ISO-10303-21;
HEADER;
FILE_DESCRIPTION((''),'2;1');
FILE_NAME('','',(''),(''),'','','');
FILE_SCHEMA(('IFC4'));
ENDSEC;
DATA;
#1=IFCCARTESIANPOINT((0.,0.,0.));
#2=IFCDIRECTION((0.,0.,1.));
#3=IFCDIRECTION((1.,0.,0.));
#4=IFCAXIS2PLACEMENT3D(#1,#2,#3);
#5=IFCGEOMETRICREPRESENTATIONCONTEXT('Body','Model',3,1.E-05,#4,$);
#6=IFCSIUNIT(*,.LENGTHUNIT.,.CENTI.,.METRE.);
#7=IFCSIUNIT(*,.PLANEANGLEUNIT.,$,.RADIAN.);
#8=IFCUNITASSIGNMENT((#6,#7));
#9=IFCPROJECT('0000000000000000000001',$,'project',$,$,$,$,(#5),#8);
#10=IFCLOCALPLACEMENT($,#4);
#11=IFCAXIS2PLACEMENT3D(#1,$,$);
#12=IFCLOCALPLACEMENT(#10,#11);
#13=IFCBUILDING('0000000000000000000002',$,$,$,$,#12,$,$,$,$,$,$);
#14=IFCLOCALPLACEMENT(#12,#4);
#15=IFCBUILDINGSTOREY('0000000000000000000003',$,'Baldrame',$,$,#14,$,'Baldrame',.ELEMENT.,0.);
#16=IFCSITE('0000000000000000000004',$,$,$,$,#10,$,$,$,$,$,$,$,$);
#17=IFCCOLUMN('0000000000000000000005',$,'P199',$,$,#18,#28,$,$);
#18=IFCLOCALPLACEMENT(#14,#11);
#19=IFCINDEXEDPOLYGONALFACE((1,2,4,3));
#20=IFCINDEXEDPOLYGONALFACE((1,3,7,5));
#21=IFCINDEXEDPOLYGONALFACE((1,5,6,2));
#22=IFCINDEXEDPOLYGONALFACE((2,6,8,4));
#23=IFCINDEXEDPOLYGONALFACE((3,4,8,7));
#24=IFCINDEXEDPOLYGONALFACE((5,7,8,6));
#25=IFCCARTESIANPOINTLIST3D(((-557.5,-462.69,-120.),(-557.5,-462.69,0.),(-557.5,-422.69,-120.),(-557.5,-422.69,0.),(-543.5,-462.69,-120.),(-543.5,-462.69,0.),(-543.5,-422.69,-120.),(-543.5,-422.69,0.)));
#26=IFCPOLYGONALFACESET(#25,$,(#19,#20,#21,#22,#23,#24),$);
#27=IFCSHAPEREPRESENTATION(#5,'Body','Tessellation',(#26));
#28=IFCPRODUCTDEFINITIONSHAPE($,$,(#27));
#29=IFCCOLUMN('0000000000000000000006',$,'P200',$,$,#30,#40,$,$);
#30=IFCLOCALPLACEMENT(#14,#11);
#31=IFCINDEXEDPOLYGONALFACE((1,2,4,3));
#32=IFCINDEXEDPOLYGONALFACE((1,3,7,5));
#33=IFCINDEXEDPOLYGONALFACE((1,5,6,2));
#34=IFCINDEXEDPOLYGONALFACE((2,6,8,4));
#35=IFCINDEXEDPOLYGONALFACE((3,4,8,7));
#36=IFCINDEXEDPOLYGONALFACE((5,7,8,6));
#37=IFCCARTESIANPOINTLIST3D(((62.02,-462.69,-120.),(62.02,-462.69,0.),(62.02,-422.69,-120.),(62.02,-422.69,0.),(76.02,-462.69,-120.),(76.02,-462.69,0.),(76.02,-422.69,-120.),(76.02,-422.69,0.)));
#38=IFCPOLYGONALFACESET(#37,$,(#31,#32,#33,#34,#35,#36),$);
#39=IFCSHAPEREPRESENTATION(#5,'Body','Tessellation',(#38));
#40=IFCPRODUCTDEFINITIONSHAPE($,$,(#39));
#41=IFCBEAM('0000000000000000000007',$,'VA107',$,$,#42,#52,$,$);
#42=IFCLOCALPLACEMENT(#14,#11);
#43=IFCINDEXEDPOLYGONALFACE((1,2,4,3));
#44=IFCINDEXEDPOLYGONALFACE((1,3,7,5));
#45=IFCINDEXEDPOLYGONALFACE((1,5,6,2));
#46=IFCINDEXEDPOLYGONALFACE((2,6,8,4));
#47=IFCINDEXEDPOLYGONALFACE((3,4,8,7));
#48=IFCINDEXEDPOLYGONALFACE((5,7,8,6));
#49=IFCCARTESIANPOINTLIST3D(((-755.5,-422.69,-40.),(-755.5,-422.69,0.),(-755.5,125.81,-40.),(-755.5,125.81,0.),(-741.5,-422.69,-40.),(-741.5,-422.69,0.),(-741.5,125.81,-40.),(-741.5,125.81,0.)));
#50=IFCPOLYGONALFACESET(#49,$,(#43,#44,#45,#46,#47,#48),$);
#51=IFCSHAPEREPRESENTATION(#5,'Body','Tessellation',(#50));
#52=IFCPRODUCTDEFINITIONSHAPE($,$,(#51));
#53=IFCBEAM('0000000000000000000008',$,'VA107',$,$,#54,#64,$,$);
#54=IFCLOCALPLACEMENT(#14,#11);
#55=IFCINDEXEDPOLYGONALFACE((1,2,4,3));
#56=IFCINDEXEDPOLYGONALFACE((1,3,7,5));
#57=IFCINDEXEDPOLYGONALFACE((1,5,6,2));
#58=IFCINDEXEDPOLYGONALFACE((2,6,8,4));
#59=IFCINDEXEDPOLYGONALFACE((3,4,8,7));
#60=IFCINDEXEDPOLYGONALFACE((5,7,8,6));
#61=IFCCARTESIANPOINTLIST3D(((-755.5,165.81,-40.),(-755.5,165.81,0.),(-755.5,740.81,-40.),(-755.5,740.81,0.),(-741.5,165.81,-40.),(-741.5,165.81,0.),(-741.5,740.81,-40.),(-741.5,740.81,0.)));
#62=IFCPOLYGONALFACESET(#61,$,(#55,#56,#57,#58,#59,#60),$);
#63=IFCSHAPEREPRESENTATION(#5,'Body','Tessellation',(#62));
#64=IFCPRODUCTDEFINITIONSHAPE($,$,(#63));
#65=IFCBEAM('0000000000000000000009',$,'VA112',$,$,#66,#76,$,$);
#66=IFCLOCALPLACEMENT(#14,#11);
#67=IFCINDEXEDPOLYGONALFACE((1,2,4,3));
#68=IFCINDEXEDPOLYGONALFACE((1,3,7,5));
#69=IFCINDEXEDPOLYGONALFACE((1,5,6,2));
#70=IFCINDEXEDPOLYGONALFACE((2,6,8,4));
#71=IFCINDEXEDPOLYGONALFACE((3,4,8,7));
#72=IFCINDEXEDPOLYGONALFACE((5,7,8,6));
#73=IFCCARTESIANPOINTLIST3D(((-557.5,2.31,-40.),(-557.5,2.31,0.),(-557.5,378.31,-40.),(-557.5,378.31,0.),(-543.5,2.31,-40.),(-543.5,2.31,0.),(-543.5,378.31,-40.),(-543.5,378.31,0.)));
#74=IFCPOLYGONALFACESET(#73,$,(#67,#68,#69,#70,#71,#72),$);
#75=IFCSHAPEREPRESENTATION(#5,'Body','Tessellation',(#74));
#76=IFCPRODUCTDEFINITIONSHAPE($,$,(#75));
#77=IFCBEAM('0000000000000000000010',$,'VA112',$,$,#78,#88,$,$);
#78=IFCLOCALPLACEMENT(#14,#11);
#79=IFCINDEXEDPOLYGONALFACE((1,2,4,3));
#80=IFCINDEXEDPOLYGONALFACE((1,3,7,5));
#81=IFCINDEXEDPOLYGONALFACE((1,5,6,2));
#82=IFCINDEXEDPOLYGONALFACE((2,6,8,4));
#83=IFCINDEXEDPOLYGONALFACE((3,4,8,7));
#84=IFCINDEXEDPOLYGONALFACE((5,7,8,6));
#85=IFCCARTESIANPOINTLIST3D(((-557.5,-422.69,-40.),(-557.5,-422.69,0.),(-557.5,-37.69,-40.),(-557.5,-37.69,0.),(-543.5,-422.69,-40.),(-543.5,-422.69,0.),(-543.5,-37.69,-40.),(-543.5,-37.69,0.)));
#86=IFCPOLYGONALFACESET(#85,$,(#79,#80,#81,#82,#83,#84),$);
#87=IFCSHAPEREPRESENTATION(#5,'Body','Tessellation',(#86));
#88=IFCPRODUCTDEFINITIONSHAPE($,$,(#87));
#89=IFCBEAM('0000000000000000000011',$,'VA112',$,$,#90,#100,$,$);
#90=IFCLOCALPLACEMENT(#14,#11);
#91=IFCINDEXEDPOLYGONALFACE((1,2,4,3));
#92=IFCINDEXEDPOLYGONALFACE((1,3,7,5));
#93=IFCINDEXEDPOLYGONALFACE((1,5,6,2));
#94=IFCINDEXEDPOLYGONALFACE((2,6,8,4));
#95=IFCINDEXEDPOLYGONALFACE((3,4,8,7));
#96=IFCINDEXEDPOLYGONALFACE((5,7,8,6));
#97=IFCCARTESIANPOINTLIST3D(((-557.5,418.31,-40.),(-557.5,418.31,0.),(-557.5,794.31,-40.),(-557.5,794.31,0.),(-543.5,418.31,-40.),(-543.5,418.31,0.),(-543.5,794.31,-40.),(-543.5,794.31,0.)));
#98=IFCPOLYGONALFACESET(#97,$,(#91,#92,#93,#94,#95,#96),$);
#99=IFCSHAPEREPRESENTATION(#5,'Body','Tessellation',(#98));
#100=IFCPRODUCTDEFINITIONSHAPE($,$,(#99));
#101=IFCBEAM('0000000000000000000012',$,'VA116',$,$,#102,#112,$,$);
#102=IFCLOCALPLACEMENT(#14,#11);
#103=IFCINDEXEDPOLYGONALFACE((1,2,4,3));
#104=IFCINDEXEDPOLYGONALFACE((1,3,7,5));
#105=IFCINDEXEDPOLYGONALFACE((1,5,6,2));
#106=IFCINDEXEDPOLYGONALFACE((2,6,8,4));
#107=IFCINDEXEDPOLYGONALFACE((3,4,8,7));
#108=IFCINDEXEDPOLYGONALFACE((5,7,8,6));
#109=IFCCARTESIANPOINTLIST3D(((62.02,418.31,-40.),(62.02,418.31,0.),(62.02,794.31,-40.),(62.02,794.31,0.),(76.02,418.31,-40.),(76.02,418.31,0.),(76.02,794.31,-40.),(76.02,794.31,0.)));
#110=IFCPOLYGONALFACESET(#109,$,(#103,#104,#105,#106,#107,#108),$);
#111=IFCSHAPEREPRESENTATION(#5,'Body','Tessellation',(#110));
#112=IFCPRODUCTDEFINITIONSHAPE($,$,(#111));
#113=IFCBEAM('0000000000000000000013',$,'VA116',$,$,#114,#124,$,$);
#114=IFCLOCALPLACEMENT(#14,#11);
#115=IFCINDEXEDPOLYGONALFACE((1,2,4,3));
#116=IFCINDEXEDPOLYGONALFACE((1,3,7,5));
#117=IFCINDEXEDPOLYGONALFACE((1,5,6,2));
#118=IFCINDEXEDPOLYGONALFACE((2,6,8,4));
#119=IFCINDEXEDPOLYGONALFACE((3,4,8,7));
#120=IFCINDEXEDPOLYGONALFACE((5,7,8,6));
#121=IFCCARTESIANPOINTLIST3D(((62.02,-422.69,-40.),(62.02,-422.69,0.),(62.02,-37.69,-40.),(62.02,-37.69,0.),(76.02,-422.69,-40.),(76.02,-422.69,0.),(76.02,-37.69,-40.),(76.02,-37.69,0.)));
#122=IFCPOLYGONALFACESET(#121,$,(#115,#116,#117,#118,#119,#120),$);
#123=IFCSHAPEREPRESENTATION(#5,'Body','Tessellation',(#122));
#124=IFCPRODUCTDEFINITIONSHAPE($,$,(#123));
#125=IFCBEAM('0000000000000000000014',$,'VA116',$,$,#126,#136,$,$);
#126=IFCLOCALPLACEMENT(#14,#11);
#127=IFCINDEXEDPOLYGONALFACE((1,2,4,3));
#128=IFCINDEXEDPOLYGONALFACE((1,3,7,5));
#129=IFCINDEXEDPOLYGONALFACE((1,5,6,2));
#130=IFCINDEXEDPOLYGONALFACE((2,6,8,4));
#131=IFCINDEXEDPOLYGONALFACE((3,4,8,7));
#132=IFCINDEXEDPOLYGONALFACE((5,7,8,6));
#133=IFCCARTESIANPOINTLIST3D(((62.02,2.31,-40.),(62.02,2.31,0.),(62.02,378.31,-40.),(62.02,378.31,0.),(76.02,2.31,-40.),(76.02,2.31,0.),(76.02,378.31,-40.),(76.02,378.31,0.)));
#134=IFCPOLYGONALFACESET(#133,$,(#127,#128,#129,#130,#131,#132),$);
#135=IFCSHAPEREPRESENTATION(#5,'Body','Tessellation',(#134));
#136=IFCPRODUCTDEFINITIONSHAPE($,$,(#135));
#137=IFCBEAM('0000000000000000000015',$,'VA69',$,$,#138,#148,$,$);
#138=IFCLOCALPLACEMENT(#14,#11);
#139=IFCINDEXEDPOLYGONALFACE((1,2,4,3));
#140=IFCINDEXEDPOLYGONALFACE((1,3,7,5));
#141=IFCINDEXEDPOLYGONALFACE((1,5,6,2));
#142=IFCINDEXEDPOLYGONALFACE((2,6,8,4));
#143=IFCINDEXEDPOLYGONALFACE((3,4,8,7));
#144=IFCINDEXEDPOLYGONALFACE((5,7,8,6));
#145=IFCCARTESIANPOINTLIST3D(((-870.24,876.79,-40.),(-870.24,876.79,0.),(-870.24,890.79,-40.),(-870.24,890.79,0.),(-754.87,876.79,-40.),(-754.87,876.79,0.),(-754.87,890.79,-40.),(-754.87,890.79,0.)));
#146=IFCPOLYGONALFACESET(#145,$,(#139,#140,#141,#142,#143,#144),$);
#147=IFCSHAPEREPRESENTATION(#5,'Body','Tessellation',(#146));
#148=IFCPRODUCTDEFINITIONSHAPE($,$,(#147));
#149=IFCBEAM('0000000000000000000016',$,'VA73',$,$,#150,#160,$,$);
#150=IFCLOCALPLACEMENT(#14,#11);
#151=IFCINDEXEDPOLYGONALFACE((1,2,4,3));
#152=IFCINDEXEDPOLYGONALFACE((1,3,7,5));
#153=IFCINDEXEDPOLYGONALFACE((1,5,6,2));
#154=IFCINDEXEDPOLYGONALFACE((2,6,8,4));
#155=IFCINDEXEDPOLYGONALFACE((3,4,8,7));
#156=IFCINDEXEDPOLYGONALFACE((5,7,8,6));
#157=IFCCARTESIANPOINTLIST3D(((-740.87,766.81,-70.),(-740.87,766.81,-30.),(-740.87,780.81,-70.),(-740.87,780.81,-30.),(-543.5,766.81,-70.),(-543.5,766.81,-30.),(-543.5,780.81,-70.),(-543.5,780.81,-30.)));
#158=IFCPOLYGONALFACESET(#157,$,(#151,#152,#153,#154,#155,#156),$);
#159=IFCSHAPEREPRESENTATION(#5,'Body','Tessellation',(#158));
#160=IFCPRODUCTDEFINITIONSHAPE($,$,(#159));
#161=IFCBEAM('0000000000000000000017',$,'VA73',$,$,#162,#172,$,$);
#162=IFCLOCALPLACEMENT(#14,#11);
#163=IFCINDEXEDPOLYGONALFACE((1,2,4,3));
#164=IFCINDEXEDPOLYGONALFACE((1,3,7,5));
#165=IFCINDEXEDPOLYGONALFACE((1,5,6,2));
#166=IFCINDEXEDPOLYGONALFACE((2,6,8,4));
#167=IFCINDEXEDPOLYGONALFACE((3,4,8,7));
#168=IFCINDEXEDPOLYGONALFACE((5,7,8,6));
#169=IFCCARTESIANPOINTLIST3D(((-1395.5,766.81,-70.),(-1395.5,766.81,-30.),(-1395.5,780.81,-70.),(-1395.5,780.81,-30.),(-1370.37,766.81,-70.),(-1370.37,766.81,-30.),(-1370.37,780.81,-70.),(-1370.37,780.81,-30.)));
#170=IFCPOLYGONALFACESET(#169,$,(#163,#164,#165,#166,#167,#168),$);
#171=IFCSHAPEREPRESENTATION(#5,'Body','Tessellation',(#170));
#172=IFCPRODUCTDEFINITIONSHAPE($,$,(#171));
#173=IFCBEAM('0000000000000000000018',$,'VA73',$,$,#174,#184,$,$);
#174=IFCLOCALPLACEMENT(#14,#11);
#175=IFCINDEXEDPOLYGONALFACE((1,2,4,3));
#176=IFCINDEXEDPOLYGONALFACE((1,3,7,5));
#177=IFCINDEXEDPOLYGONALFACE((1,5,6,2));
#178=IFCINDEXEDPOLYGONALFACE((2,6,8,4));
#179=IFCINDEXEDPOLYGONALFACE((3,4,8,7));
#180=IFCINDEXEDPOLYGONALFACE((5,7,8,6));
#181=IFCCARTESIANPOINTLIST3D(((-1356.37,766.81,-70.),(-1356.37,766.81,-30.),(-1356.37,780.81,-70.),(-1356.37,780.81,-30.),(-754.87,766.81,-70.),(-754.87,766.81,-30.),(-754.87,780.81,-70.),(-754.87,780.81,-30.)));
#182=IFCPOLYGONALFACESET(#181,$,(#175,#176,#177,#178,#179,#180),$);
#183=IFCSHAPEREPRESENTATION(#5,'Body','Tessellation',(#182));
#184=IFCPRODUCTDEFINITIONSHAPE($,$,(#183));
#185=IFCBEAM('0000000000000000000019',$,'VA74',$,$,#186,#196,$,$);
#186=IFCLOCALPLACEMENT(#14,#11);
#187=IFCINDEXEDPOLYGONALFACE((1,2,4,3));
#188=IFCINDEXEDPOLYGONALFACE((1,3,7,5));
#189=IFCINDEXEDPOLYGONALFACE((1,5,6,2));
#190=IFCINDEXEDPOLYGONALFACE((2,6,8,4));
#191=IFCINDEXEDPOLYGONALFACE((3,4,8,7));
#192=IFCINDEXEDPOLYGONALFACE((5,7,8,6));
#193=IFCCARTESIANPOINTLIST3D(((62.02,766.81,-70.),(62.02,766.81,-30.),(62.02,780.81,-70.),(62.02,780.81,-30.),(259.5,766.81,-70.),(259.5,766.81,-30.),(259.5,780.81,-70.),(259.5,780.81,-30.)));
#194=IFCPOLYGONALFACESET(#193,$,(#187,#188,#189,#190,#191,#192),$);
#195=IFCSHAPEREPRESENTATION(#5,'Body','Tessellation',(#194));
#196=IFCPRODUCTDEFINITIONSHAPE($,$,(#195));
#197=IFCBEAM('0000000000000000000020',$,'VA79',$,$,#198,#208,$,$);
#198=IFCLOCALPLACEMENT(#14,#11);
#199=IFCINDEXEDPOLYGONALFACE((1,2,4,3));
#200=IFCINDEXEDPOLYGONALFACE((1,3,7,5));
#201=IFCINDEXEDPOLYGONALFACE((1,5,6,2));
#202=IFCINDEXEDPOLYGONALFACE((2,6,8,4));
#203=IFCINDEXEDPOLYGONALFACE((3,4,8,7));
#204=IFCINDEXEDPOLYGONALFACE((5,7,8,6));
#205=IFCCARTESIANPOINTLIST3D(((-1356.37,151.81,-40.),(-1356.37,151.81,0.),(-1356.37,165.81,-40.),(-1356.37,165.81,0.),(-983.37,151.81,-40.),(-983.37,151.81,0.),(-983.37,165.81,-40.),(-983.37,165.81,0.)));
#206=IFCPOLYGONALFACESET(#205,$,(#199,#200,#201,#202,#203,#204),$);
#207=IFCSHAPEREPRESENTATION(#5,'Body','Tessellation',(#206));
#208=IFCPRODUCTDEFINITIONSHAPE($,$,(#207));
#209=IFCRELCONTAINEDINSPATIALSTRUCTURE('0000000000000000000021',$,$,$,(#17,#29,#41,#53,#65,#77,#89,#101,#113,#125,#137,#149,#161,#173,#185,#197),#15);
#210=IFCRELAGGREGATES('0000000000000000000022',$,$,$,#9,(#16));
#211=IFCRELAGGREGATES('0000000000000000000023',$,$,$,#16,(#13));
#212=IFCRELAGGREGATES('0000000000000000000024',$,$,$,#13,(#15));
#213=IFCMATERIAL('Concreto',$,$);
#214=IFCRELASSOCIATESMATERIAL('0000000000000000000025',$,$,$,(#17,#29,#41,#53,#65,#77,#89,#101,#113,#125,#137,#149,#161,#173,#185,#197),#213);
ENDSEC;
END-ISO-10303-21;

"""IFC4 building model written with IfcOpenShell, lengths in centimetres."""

from ifc_helpers import new_model, si_unit, frame, origin, origin_with_axes, origin_2d_with_axis, place, context, project, spatial, rectangle, extrude, material, element, save


model = new_model("IFC4")

# Units and contexts
model_context = context("Model", 3, precision=1e-05, world=origin_with_axes(), identifier="Body")
ifc_project = project(units=[si_unit("LENGTHUNIT", "METRE", prefix="CENTI"), si_unit("PLANEANGLEUNIT", "RADIAN")], contexts=[model_context])

# Site, building, storey
site_placement = place(None, origin_with_axes())
site = spatial("IfcSite", under=ifc_project, at=site_placement)
building_placement = place(site_placement, origin())
building = spatial("IfcBuilding", under=site, at=building_placement)
storey_placement = place(building_placement, origin_with_axes())
storey = spatial("IfcBuildingStorey", under=building, at=storey_placement, Name="Baldrame", LongName="Baldrame", CompositionType="ELEMENT", Elevation=0.0)

# Shared definitions
ifc_material = material(Name="Concreto")

# Columns
for number, where, z_axis, x_axis, name in (
    (1, (-550.5, -442.69, 0.0), (0.0, 0.0, 1.0), (1.0, 0.0, 0.0), "P199"),
    (2, (69.02, -442.69, 0.0), (0.0, 0.0, 1.0), (1.0, 0.0, 0.0), "P200"),
):
    element("IfcColumn", number, at=place(storey_placement, frame(where, z_axis=z_axis, x_axis=x_axis)), inside=storey, material=ifc_material, Name=name, context=model_context, shape_type="SolidModel", body=[
        extrude(rectangle(XDim=14.0, YDim=40.0, at=origin_2d_with_axis()), frame((0.0, 0.0, -120.0), z_axis=(0.0, 0.0, 1.0), x_axis=(1.0, 0.0, 0.0)), (0.0, 0.0, 1.0), 120.0),
    ])

# Beams
beam_1_placement = place(storey_placement, frame((-748.5, -148.44, 0.0), z_axis=(0.0, 0.0, 1.0), x_axis=(1.0, 0.0, 0.0)))
element("IfcBeam", 3, at=beam_1_placement, inside=storey, material=ifc_material, Name="VA107", context=model_context, shape_type="SolidModel", body=[
    extrude(rectangle(XDim=14.0, YDim=40.0, at=origin_2d_with_axis()), frame((0.0, -274.25, -20.0), z_axis=(0.0, 1.0, 0.0), x_axis=(-1.0, 0.0, 0.0)), (0.0, 0.0, 1.0), 548.5),
])
beam_2_placement = place(storey_placement, frame((-748.5, 453.31, 0.0), z_axis=(0.0, 0.0, 1.0), x_axis=(1.0, 0.0, 0.0)))
element("IfcBeam", 4, at=beam_2_placement, inside=storey, material=ifc_material, Name="VA107", context=model_context, shape_type="SolidModel", body=[
    extrude(rectangle(XDim=14.0, YDim=40.0, at=origin_2d_with_axis()), frame((0.0, -287.5, -20.0), z_axis=(0.0, 1.0, 0.0), x_axis=(-1.0, 0.0, 0.0)), (0.0, 0.0, 1.0), 575.0),
])
beam_3_placement = place(storey_placement, frame((-550.5, 190.31, 0.0), z_axis=(0.0, 0.0, 1.0), x_axis=(1.0, 0.0, 0.0)))
element("IfcBeam", 5, at=beam_3_placement, inside=storey, material=ifc_material, Name="VA112", context=model_context, shape_type="SolidModel", body=[
    extrude(rectangle(XDim=14.0, YDim=40.0, at=origin_2d_with_axis()), frame((0.0, -188.0, -20.0), z_axis=(0.0, 1.0, 0.0), x_axis=(-1.0, 0.0, 0.0)), (0.0, 0.0, 1.0), 376.0),
])
beam_4_placement = place(storey_placement, frame((-550.5, -230.19, 0.0), z_axis=(0.0, 0.0, 1.0), x_axis=(1.0, 0.0, 0.0)))
element("IfcBeam", 6, at=beam_4_placement, inside=storey, material=ifc_material, Name="VA112", context=model_context, shape_type="SolidModel", body=[
    extrude(rectangle(XDim=14.0, YDim=40.0, at=origin_2d_with_axis()), frame((0.0, -192.5, -20.0), z_axis=(0.0, 1.0, 0.0), x_axis=(-1.0, 0.0, 0.0)), (0.0, 0.0, 1.0), 385.0),
])
for number, where, z_axis, x_axis, name in (
    (7, (-550.5, 606.31, 0.0), (0.0, 0.0, 1.0), (1.0, 0.0, 0.0), "VA112"),
    (8, (69.02, 606.31, 0.0), (0.0, 0.0, 1.0), (1.0, 0.0, 0.0), "VA116"),
):
    element("IfcBeam", number, at=place(storey_placement, frame(where, z_axis=z_axis, x_axis=x_axis)), inside=storey, material=ifc_material, Name=name, context=model_context, shape_type="SolidModel", body=[
        extrude(rectangle(XDim=14.0, YDim=40.0, at=origin_2d_with_axis()), frame((0.0, -188.0, -20.0), z_axis=(0.0, 1.0, 0.0), x_axis=(-1.0, 0.0, 0.0)), (0.0, 0.0, 1.0), 376.0),
    ])
beam_5_placement = place(storey_placement, frame((69.02, -230.19, 0.0), z_axis=(0.0, 0.0, 1.0), x_axis=(1.0, 0.0, 0.0)))
element("IfcBeam", 9, at=beam_5_placement, inside=storey, material=ifc_material, Name="VA116", context=model_context, shape_type="SolidModel", body=[
    extrude(rectangle(XDim=14.0, YDim=40.0, at=origin_2d_with_axis()), frame((0.0, -192.5, -20.0), z_axis=(0.0, 1.0, 0.0), x_axis=(1.0, 0.0, 0.0)), (0.0, 0.0, 1.0), 385.0),
])
beam_6_placement = place(storey_placement, frame((69.02, 190.31, 0.0), z_axis=(0.0, 0.0, 1.0), x_axis=(1.0, 0.0, 0.0)))
element("IfcBeam", 10, at=beam_6_placement, inside=storey, material=ifc_material, Name="VA116", context=model_context, shape_type="SolidModel", body=[
    extrude(rectangle(XDim=14.0, YDim=40.0, at=origin_2d_with_axis()), frame((0.0, -188.0, -20.0), z_axis=(0.0, 1.0, 0.0), x_axis=(1.0, 0.0, 0.0)), (0.0, 0.0, 1.0), 376.0),
])
beam_7_placement = place(storey_placement, frame((-812.56, 883.79, 0.0), z_axis=(0.0, 0.0, 1.0), x_axis=(1.0, 0.0, 0.0)))
element("IfcBeam", 11, at=beam_7_placement, inside=storey, material=ifc_material, Name="VA69", context=model_context, shape_type="SolidModel", body=[
    extrude(rectangle(XDim=14.0, YDim=40.0, at=origin_2d_with_axis()), frame((-57.69, 0.0, -20.0), z_axis=(1.0, 0.0, 0.0), x_axis=(0.0, 1.0, 0.0)), (0.0, 0.0, 1.0), 115.37),
])
beam_8_placement = place(storey_placement, frame((-642.18, 773.81, -30.0), z_axis=(0.0, 0.0, 1.0), x_axis=(1.0, 0.0, 0.0)))
element("IfcBeam", 12, at=beam_8_placement, inside=storey, material=ifc_material, Name="VA73", context=model_context, shape_type="SolidModel", body=[
    extrude(rectangle(XDim=14.0, YDim=40.0, at=origin_2d_with_axis()), frame((-98.69, 0.0, -20.0), z_axis=(1.0, 0.0, 0.0), x_axis=(0.0, 1.0, 0.0)), (0.0, 0.0, 1.0), 197.37),
])
beam_9_placement = place(storey_placement, frame((-1382.93, 773.81, -30.0), z_axis=(0.0, 0.0, 1.0), x_axis=(1.0, 0.0, 0.0)))
element("IfcBeam", 13, at=beam_9_placement, inside=storey, material=ifc_material, Name="VA73", context=model_context, shape_type="SolidModel", body=[
    extrude(rectangle(XDim=14.0, YDim=40.0, at=origin_2d_with_axis()), frame((-12.56, 0.0, -20.0), z_axis=(1.0, 0.0, 0.0), x_axis=(0.0, -1.0, 0.0)), (0.0, 0.0, 1.0), 25.13),
])
beam_10_placement = place(storey_placement, frame((-1055.62, 773.81, -30.0), z_axis=(0.0, 0.0, 1.0), x_axis=(1.0, 0.0, 0.0)))
element("IfcBeam", 14, at=beam_10_placement, inside=storey, material=ifc_material, Name="VA73", context=model_context, shape_type="SolidModel", body=[
    extrude(rectangle(XDim=14.0, YDim=40.0, at=origin_2d_with_axis()), frame((-300.75, 0.0, -20.0), z_axis=(1.0, 0.0, 0.0), x_axis=(0.0, -1.0, 0.0)), (0.0, 0.0, 1.0), 601.5),
])
beam_11_placement = place(storey_placement, frame((160.76, 773.81, -30.0), z_axis=(0.0, 0.0, 1.0), x_axis=(1.0, 0.0, 0.0)))
element("IfcBeam", 15, at=beam_11_placement, inside=storey, material=ifc_material, Name="VA74", context=model_context, shape_type="SolidModel", body=[
    extrude(rectangle(XDim=14.0, YDim=40.0, at=origin_2d_with_axis()), frame((-98.74, 0.0, -20.0), z_axis=(1.0, 0.0, 0.0), x_axis=(0.0, 1.0, 0.0)), (0.0, 0.0, 1.0), 197.48),
])
beam_12_placement = place(storey_placement, frame((-1169.87, 158.81, 0.0), z_axis=(0.0, 0.0, 1.0), x_axis=(1.0, 0.0, 0.0)))
element("IfcBeam", 16, at=beam_12_placement, inside=storey, material=ifc_material, Name="VA79", context=model_context, shape_type="SolidModel", body=[
    extrude(rectangle(XDim=14.0, YDim=40.0, at=origin_2d_with_axis()), frame((-186.5, 0.0, -20.0), z_axis=(1.0, 0.0, 0.0), x_axis=(0.0, -1.0, 0.0)), (0.0, 0.0, 1.0), 373.0),
])

save(model, "model.ifc")
